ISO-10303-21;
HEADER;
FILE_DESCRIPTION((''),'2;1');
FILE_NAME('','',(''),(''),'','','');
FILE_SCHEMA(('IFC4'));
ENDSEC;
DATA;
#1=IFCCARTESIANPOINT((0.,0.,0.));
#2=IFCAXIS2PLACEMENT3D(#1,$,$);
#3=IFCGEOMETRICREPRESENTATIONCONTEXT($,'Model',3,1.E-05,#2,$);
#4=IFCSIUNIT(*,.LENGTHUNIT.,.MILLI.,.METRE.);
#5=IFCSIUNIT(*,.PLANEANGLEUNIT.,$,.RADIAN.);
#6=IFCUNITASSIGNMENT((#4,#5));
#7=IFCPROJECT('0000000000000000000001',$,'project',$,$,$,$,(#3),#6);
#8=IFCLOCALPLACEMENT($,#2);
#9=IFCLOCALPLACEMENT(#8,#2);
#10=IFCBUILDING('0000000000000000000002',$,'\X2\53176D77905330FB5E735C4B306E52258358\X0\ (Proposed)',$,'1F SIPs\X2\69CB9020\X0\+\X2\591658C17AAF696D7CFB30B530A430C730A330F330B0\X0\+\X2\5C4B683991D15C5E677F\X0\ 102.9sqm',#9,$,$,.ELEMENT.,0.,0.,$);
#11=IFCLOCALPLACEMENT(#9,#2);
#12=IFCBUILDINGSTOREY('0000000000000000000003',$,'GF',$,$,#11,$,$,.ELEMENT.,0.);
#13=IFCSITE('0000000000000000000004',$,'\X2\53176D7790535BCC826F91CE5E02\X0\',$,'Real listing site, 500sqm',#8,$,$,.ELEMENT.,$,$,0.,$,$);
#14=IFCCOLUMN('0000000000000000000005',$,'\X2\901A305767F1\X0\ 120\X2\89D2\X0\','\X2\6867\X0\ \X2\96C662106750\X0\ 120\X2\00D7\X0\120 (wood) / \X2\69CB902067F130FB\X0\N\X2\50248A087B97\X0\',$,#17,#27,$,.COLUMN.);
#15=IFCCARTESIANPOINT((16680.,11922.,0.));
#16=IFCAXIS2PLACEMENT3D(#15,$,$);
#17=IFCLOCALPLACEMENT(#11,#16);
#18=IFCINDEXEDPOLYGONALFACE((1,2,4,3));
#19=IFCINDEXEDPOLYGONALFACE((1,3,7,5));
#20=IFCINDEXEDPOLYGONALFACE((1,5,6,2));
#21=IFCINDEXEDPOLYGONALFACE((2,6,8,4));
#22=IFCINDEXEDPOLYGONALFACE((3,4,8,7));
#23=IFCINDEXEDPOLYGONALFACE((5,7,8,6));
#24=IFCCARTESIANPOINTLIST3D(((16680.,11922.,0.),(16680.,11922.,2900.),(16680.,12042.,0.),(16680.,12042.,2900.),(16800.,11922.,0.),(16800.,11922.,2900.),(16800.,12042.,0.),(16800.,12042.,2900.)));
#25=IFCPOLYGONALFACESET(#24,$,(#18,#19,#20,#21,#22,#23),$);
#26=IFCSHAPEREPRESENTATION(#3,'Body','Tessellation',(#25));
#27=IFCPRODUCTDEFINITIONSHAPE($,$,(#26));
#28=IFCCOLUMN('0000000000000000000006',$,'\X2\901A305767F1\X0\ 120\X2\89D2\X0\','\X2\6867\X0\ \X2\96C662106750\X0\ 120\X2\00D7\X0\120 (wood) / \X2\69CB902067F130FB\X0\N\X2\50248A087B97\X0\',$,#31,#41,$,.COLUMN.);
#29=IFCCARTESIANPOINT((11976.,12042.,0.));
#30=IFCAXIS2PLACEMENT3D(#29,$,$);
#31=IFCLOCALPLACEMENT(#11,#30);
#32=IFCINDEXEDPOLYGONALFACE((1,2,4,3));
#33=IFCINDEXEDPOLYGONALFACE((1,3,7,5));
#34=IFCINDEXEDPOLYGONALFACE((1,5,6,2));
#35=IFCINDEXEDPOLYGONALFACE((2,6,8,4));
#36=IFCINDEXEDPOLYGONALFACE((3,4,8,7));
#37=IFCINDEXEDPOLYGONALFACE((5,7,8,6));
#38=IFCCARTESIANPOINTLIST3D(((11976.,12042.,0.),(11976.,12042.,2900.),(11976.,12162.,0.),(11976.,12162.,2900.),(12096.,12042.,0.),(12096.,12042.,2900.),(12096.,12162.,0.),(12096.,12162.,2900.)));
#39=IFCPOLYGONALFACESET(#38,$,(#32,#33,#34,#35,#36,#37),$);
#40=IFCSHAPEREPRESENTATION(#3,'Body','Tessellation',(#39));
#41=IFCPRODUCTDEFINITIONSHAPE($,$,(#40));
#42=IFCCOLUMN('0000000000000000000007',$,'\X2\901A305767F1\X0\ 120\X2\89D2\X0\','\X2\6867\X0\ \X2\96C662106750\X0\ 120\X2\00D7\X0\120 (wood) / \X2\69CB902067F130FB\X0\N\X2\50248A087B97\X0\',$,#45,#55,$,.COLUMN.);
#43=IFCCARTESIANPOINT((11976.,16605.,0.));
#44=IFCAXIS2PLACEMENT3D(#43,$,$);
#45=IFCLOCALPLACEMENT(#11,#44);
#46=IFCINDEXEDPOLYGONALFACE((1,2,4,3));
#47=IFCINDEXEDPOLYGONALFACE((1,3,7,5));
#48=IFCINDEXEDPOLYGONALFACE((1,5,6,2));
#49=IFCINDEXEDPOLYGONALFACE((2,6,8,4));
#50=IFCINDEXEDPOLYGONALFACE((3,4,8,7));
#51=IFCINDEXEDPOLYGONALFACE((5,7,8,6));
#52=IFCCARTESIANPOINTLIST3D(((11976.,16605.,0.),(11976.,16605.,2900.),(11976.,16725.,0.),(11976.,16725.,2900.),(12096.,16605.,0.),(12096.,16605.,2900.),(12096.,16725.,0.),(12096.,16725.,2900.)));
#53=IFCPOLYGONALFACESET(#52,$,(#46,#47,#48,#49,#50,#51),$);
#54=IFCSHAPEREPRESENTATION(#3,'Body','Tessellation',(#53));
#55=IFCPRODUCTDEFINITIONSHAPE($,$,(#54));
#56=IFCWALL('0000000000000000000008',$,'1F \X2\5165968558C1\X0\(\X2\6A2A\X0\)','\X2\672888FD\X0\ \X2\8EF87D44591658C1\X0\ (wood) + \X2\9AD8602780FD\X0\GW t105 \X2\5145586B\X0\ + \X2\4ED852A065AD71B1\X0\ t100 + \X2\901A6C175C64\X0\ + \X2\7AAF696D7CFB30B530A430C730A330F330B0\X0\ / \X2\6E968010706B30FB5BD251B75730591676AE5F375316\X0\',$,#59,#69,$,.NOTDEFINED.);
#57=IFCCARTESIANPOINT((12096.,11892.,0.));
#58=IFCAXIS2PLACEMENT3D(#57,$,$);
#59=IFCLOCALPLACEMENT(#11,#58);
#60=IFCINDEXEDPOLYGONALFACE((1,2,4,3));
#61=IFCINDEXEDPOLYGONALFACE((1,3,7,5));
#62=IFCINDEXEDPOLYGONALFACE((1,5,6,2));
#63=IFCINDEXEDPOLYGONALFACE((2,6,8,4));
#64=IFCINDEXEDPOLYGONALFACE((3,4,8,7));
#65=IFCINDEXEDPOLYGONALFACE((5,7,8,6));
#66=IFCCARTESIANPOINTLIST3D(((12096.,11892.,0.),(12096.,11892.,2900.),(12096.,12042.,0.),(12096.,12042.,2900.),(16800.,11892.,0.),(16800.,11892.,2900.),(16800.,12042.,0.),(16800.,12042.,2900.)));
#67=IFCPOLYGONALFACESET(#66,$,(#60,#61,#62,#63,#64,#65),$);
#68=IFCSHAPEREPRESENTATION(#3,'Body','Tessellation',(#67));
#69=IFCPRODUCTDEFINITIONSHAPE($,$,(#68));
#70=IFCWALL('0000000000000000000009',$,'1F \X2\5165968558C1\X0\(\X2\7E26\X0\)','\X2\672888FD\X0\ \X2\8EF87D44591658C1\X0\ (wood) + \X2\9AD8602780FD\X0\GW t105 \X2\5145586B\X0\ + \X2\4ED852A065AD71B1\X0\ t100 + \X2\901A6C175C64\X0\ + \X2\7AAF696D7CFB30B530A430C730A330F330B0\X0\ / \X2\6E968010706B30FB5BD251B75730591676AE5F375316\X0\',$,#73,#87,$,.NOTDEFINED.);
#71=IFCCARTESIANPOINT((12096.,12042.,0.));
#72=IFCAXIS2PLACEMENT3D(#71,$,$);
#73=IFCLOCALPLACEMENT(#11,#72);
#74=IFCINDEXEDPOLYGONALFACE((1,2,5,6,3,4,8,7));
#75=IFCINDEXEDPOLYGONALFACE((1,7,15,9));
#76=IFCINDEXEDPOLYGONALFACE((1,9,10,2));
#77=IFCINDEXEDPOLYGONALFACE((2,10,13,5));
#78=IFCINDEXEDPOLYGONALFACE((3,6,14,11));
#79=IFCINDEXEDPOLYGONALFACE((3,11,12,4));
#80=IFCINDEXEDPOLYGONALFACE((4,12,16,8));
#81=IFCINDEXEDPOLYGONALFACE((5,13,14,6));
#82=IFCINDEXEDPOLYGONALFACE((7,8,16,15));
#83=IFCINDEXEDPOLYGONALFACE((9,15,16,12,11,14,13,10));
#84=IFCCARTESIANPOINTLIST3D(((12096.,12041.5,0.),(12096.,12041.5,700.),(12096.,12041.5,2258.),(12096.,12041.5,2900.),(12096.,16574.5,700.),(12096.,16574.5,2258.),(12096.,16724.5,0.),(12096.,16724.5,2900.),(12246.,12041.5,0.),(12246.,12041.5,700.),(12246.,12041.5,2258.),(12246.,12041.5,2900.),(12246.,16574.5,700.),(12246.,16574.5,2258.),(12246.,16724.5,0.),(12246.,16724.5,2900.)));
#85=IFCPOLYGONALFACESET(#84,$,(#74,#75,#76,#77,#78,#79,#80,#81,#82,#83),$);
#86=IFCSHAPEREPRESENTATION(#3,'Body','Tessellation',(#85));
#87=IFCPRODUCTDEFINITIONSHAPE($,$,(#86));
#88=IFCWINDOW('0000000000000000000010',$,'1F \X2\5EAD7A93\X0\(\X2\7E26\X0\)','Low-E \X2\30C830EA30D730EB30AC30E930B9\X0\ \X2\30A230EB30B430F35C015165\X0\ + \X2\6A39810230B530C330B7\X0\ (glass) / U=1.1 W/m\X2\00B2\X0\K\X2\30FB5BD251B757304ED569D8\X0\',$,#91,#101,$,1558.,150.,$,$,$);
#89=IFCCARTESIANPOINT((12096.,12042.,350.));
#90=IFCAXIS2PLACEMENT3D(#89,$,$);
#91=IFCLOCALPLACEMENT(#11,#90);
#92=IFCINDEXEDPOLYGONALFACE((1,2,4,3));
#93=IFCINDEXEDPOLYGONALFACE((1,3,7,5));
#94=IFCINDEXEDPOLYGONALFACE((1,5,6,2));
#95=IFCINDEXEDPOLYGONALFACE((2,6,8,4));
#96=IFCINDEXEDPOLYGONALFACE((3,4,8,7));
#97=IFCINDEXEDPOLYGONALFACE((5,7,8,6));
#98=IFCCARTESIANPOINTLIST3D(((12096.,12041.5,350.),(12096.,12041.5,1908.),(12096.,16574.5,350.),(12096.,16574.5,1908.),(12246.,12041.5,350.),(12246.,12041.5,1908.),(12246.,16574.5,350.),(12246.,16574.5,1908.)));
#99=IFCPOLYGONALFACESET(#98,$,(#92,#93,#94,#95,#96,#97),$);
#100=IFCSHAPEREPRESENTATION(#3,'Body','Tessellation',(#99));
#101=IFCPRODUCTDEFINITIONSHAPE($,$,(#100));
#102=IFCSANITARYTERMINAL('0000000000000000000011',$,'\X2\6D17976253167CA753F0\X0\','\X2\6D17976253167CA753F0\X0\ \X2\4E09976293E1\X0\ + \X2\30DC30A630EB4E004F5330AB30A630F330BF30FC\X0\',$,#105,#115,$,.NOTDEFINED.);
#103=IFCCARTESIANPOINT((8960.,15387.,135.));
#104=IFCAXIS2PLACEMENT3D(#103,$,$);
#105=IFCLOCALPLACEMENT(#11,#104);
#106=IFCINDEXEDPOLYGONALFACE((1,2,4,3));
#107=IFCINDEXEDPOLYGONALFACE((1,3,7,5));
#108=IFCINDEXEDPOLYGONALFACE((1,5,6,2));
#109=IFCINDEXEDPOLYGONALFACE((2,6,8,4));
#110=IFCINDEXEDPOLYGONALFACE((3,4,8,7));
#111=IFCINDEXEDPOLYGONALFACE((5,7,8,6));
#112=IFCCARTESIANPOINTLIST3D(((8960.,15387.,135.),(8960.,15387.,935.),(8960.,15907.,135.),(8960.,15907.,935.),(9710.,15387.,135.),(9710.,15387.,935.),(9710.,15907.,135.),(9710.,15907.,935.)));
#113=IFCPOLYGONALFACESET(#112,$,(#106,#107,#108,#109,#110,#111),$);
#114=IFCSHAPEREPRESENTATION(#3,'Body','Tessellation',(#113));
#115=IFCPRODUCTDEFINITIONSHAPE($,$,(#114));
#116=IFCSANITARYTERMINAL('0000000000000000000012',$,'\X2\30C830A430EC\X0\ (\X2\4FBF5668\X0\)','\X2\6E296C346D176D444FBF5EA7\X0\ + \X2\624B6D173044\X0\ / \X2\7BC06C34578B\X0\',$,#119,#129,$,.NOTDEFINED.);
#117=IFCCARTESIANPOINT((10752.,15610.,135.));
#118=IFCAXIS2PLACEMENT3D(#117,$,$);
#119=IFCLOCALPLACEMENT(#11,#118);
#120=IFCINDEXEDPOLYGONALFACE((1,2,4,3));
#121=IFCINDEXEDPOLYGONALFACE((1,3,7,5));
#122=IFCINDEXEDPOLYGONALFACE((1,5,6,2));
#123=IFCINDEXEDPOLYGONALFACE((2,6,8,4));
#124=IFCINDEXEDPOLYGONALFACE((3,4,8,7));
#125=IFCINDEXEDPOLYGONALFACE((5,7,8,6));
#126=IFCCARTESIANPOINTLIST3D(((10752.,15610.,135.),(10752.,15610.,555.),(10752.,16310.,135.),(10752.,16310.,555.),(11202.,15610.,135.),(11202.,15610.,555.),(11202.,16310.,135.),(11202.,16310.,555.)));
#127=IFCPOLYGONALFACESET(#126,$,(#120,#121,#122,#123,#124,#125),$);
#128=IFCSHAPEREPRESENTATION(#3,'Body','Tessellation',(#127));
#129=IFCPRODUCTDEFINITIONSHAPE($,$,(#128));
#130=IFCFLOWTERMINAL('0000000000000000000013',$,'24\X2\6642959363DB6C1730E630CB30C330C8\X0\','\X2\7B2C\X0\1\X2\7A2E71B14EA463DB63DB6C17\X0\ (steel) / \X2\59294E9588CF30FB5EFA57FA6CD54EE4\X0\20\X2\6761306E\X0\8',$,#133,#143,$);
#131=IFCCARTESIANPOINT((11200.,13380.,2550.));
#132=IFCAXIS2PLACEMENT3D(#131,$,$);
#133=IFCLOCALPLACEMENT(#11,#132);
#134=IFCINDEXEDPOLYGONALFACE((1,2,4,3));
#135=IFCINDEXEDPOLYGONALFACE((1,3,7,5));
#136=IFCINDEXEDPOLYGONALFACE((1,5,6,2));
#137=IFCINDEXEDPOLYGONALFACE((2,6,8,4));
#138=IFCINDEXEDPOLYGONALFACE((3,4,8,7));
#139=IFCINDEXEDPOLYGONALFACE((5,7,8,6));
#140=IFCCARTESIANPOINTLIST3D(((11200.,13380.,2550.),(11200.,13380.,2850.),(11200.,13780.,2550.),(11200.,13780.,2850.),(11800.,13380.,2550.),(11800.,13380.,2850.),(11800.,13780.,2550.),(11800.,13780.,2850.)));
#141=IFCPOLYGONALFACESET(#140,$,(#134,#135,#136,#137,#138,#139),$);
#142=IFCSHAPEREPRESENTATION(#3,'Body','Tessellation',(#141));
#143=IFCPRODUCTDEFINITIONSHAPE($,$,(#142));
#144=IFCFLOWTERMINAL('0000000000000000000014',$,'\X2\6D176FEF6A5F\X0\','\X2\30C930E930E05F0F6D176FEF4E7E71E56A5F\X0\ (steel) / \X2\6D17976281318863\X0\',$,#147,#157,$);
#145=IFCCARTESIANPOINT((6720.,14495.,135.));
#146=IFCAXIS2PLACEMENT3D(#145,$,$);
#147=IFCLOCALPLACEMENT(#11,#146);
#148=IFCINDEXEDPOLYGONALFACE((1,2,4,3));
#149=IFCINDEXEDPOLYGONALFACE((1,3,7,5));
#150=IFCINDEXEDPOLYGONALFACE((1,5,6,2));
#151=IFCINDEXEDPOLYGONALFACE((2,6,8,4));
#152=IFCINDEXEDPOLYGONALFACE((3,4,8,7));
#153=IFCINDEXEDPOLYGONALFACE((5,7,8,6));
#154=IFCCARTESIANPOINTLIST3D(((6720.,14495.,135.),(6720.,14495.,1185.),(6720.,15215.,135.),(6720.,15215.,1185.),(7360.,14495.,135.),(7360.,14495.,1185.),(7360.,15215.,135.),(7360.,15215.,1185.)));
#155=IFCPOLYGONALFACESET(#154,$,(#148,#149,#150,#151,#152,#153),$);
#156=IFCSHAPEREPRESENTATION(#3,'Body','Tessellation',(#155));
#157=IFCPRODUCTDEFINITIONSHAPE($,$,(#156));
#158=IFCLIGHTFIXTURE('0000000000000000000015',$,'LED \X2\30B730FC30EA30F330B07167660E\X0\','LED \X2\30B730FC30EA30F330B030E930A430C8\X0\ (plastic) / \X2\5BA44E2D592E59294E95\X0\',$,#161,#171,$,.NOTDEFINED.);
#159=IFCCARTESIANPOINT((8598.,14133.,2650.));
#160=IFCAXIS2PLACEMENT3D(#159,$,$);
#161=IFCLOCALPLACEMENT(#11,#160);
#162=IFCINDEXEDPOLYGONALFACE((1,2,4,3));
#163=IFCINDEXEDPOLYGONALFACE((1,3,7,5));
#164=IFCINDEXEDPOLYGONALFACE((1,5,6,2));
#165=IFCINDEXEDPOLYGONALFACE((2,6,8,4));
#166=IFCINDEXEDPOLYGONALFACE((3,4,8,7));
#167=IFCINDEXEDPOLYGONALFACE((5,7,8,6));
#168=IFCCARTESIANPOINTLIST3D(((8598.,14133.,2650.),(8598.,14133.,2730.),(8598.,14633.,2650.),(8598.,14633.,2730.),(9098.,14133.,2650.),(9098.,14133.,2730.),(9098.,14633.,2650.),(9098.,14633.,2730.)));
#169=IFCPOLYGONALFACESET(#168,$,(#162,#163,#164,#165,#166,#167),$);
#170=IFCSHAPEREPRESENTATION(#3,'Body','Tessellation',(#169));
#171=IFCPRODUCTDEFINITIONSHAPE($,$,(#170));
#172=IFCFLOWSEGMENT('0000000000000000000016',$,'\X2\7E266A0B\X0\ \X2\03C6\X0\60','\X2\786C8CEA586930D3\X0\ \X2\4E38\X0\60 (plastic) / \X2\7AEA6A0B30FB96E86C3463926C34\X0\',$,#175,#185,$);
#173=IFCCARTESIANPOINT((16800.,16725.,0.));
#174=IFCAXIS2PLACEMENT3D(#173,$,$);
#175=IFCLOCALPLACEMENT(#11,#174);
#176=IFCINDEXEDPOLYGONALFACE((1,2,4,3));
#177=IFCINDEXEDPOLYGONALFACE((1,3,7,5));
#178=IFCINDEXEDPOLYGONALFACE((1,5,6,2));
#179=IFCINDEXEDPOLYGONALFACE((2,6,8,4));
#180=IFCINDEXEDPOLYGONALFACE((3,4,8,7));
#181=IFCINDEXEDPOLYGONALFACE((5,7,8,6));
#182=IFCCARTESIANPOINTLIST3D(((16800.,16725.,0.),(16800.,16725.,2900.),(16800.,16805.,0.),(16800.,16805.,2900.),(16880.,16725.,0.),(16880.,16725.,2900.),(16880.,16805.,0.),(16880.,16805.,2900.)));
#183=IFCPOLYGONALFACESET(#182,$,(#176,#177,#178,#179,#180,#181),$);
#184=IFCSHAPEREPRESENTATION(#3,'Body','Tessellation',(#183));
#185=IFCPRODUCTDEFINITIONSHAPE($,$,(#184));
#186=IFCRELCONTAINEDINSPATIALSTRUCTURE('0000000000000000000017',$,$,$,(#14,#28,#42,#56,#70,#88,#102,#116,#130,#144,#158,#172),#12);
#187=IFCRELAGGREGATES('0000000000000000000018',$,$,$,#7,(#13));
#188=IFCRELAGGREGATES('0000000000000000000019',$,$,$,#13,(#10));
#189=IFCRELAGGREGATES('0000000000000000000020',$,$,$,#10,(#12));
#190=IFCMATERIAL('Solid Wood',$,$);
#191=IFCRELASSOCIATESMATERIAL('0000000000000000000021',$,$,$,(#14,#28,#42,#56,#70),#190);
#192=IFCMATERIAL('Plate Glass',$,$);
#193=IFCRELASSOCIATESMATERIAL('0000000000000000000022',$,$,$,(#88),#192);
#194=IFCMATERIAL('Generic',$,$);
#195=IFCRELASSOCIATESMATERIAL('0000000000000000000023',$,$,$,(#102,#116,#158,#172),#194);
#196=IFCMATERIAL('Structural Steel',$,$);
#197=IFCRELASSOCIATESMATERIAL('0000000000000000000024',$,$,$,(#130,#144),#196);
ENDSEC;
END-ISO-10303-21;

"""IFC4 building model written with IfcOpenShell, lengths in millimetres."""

from ifc_helpers import new_model, si_unit, frame, frame_2d, origin, place, context, project, spatial, rectangle, extrude, material, element, fill, save


model = new_model("IFC4")

# Units and contexts
model_context = context("Model", 3, precision=1e-05, world=origin())
ifc_project = project(units=[si_unit("LENGTHUNIT", "METRE", prefix="MILLI"), si_unit("PLANEANGLEUNIT", "RADIAN")], contexts=[model_context])

# Site, building, storey
site_placement = place(None, origin())
site = spatial("IfcSite", under=ifc_project, at=site_placement, Name="北海道富良野市", ObjectType="Real listing site, 500sqm", CompositionType="ELEMENT", RefElevation=0.0)
building_placement = place(site_placement, origin())
building = spatial("IfcBuilding", under=site, at=building_placement, Name="北海道・平屋の別荘 (Proposed)", ObjectType="1F SIPs構造+外壁窯業系サイディング+屋根金属板 102.9sqm", CompositionType="ELEMENT", ElevationOfRefHeight=0.0, ElevationOfTerrain=0.0)
storey_placement = place(building_placement, origin())
storey = spatial("IfcBuildingStorey", under=building, at=storey_placement, Name="GF", CompositionType="ELEMENT", Elevation=0.0)

# Columns
ifc_material_1 = material(Name="Solid Wood")
column_1_placement = place(storey_placement, frame((16680.0, 11922.0, 0.0)))
element("IfcColumn", 1, at=column_1_placement, inside=storey, material=ifc_material_1, Name="通し柱 120角", Description="桧 集成材 120×120 (wood) / 構造柱・N値計算", PredefinedType="COLUMN", context=model_context, shape_type="SweptSolid", body=[
    extrude(rectangle(XDim=120.0, YDim=120.0, at=frame_2d((60.0, 60.0))), frame((16680.0, 11922.0, 0.0)), (0.0, 0.0, 1.0), 2900.0),
])
column_2_placement = place(storey_placement, frame((11976.0, 12042.0, 0.0)))
element("IfcColumn", 2, at=column_2_placement, inside=storey, material=ifc_material_1, Name="通し柱 120角", Description="桧 集成材 120×120 (wood) / 構造柱・N値計算", PredefinedType="COLUMN", context=model_context, shape_type="SweptSolid", body=[
    extrude(rectangle(XDim=120.0, YDim=120.0, at=frame_2d((60.0, 60.0))), frame((11976.0, 12042.0, 0.0)), (0.0, 0.0, 1.0), 2900.0),
])
column_3_placement = place(storey_placement, frame((11976.0, 16605.0, 0.0)))
element("IfcColumn", 3, at=column_3_placement, inside=storey, material=ifc_material_1, Name="通し柱 120角", Description="桧 集成材 120×120 (wood) / 構造柱・N値計算", PredefinedType="COLUMN", context=model_context, shape_type="SweptSolid", body=[
    extrude(rectangle(XDim=120.0, YDim=120.0, at=frame_2d((60.0, 60.0))), frame((11976.0, 16605.0, 0.0)), (0.0, 0.0, 1.0), 2900.0),
])

# Wall
wall_1_placement = place(storey_placement, frame((12096.0, 11892.0, 0.0)))
element("IfcWall", 4, at=wall_1_placement, inside=storey, material=ifc_material_1, Name="1F 入隅壁(横)", Description="木製 軸組外壁 (wood) + 高性能GW t105 充填 + 付加断熱 t100 + 通気層 + 窯業系サイディング / 準耐火・寒冷地外皮強化", PredefinedType="NOTDEFINED", context=model_context, shape_type="SweptSolid", body=[
    extrude(rectangle(XDim=4704.0, YDim=150.0, at=frame_2d((2352.0, 75.0))), frame((12096.0, 11892.0, 0.0)), (0.0, 0.0, 1.0), 2900.0),
])

# Wall, opening, window
wall_2_placement = place(storey_placement, frame((12096.0, 12042.0, 0.0)))
wall_2 = element("IfcWall", 5, at=wall_2_placement, inside=storey, material=ifc_material_1, Name="1F 入隅壁(縦)", Description="木製 軸組外壁 (wood) + 高性能GW t105 充填 + 付加断熱 t100 + 通気層 + 窯業系サイディング / 準耐火・寒冷地外皮強化", PredefinedType="NOTDEFINED", context=model_context, shape_type="SweptSolid", body=[
    extrude(rectangle(XDim=150.0, YDim=4683.0, at=frame_2d((75.0, 2341.0))), frame((12096.0, 12042.0, 0.0)), (0.0, 0.0, 1.0), 2900.0),
])
opening_placement = place(storey_placement, frame((12096.0, 12042.0, 350.0)))
opening = element("IfcOpeningElement", 6, at=opening_placement, cuts=wall_2, PredefinedType="NOTDEFINED", context=model_context, shape_type="SweptSolid", body=[
    extrude(rectangle(XDim=150.0, YDim=4533.0, at=frame_2d((75.0, 2266.0))), frame((12096.0, 12042.0, 350.0)), (0.0, 0.0, 1.0), 1558.0),
])
ifc_material_2 = material(Name="Plate Glass")
window_placement = place(storey_placement, frame((12096.0, 12042.0, 350.0)))
window = element("IfcWindow", 7, at=window_placement, inside=storey, material=ifc_material_2, Name="1F 庭窓(縦)", Description="Low-E トリプルガラス アルゴン封入 + 樹脂サッシ (glass) / U=1.1 W/m²K・寒冷地仕様", OverallHeight=1558.0, OverallWidth=150.0, context=model_context, shape_type="SweptSolid", body=[
    extrude(rectangle(XDim=150.0, YDim=4533.0, at=frame_2d((75.0, 2266.0))), frame((12096.0, 12042.0, 350.0)), (0.0, 0.0, 1.0), 1558.0),
])
fill(opening, window)

# Sanitary terminals
ifc_material_3 = material(Name="Generic")
sanitary_terminal_1_placement = place(storey_placement, frame((8960.0, 15387.0, 135.0)))
element("IfcSanitaryTerminal", 8, at=sanitary_terminal_1_placement, inside=storey, material=ifc_material_3, Name="洗面化粧台", Description="洗面化粧台 三面鏡 + ボウル一体カウンター", PredefinedType="NOTDEFINED", context=model_context, shape_type="SweptSolid", body=[
    extrude(rectangle(XDim=750.0, YDim=520.0, at=frame_2d((375.0, 260.0))), frame((8960.0, 15387.0, 135.0)), (0.0, 0.0, 1.0), 800.0),
])
sanitary_terminal_2_placement = place(storey_placement, frame((10752.0, 15610.0, 135.0)))
element("IfcSanitaryTerminal", 9, at=sanitary_terminal_2_placement, inside=storey, material=ifc_material_3, Name="トイレ (便器)", Description="温水洗浄便座 + 手洗い / 節水型", PredefinedType="NOTDEFINED", context=model_context, shape_type="SweptSolid", body=[
    extrude(rectangle(XDim=450.0, YDim=700.0, at=frame_2d((225.0, 350.0))), frame((10752.0, 15610.0, 135.0)), (0.0, 0.0, 1.0), 420.0),
])

# Flow terminals
ifc_material_4 = material(Name="Structural Steel")
flow_terminal_1_placement = place(storey_placement, frame((11200.0, 13380.0, 2550.0)))
element("IfcFlowTerminal", 10, at=flow_terminal_1_placement, inside=storey, material=ifc_material_4, Name="24時間換気ユニット", Description="第1種熱交換換気 (steel) / 天井裏・建基法令20条の8", context=model_context, shape_type="SweptSolid", body=[
    extrude(rectangle(XDim=600.0, YDim=400.0, at=frame_2d((300.0, 200.0))), frame((11200.0, 13380.0, 2550.0)), (0.0, 0.0, 1.0), 300.0),
])
flow_terminal_2_placement = place(storey_placement, frame((6720.0, 14495.0, 135.0)))
element("IfcFlowTerminal", 11, at=flow_terminal_2_placement, inside=storey, material=ifc_material_4, Name="洗濯機", Description="ドラム式洗濯乾燥機 (steel) / 洗面脱衣", context=model_context, shape_type="SweptSolid", body=[
    extrude(rectangle(XDim=640.0, YDim=720.0, at=frame_2d((320.0, 360.0))), frame((6720.0, 14495.0, 135.0)), (0.0, 0.0, 1.0), 1050.0),
])

# Light fixture
light_fixture_placement = place(storey_placement, frame((8598.0, 14133.0, 2650.0)))
element("IfcLightFixture", 12, at=light_fixture_placement, inside=storey, material=ifc_material_3, Name="LED シーリング照明", Description="LED シーリングライト (plastic) / 室中央天井", PredefinedType="NOTDEFINED", context=model_context, shape_type="SweptSolid", body=[
    extrude(rectangle(XDim=500.0, YDim=500.0, at=frame_2d((250.0, 250.0))), frame((8598.0, 14133.0, 2650.0)), (0.0, 0.0, 1.0), 80.0),
])

# Flow segment
flow_segment_placement = place(storey_placement, frame((16800.0, 16725.0, 0.0)))
element("IfcFlowSegment", 13, at=flow_segment_placement, inside=storey, material=ifc_material_3, Name="縦樋 φ60", Description="硬質塩ビ 丸60 (plastic) / 竪樋・雨水排水", context=model_context, shape_type="SweptSolid", body=[
    extrude(rectangle(XDim=80.0, YDim=80.0, at=frame_2d((40.0, 40.0))), frame((16800.0, 16725.0, 0.0)), (0.0, 0.0, 1.0), 2900.0),
])

save(model, "model.ifc")
